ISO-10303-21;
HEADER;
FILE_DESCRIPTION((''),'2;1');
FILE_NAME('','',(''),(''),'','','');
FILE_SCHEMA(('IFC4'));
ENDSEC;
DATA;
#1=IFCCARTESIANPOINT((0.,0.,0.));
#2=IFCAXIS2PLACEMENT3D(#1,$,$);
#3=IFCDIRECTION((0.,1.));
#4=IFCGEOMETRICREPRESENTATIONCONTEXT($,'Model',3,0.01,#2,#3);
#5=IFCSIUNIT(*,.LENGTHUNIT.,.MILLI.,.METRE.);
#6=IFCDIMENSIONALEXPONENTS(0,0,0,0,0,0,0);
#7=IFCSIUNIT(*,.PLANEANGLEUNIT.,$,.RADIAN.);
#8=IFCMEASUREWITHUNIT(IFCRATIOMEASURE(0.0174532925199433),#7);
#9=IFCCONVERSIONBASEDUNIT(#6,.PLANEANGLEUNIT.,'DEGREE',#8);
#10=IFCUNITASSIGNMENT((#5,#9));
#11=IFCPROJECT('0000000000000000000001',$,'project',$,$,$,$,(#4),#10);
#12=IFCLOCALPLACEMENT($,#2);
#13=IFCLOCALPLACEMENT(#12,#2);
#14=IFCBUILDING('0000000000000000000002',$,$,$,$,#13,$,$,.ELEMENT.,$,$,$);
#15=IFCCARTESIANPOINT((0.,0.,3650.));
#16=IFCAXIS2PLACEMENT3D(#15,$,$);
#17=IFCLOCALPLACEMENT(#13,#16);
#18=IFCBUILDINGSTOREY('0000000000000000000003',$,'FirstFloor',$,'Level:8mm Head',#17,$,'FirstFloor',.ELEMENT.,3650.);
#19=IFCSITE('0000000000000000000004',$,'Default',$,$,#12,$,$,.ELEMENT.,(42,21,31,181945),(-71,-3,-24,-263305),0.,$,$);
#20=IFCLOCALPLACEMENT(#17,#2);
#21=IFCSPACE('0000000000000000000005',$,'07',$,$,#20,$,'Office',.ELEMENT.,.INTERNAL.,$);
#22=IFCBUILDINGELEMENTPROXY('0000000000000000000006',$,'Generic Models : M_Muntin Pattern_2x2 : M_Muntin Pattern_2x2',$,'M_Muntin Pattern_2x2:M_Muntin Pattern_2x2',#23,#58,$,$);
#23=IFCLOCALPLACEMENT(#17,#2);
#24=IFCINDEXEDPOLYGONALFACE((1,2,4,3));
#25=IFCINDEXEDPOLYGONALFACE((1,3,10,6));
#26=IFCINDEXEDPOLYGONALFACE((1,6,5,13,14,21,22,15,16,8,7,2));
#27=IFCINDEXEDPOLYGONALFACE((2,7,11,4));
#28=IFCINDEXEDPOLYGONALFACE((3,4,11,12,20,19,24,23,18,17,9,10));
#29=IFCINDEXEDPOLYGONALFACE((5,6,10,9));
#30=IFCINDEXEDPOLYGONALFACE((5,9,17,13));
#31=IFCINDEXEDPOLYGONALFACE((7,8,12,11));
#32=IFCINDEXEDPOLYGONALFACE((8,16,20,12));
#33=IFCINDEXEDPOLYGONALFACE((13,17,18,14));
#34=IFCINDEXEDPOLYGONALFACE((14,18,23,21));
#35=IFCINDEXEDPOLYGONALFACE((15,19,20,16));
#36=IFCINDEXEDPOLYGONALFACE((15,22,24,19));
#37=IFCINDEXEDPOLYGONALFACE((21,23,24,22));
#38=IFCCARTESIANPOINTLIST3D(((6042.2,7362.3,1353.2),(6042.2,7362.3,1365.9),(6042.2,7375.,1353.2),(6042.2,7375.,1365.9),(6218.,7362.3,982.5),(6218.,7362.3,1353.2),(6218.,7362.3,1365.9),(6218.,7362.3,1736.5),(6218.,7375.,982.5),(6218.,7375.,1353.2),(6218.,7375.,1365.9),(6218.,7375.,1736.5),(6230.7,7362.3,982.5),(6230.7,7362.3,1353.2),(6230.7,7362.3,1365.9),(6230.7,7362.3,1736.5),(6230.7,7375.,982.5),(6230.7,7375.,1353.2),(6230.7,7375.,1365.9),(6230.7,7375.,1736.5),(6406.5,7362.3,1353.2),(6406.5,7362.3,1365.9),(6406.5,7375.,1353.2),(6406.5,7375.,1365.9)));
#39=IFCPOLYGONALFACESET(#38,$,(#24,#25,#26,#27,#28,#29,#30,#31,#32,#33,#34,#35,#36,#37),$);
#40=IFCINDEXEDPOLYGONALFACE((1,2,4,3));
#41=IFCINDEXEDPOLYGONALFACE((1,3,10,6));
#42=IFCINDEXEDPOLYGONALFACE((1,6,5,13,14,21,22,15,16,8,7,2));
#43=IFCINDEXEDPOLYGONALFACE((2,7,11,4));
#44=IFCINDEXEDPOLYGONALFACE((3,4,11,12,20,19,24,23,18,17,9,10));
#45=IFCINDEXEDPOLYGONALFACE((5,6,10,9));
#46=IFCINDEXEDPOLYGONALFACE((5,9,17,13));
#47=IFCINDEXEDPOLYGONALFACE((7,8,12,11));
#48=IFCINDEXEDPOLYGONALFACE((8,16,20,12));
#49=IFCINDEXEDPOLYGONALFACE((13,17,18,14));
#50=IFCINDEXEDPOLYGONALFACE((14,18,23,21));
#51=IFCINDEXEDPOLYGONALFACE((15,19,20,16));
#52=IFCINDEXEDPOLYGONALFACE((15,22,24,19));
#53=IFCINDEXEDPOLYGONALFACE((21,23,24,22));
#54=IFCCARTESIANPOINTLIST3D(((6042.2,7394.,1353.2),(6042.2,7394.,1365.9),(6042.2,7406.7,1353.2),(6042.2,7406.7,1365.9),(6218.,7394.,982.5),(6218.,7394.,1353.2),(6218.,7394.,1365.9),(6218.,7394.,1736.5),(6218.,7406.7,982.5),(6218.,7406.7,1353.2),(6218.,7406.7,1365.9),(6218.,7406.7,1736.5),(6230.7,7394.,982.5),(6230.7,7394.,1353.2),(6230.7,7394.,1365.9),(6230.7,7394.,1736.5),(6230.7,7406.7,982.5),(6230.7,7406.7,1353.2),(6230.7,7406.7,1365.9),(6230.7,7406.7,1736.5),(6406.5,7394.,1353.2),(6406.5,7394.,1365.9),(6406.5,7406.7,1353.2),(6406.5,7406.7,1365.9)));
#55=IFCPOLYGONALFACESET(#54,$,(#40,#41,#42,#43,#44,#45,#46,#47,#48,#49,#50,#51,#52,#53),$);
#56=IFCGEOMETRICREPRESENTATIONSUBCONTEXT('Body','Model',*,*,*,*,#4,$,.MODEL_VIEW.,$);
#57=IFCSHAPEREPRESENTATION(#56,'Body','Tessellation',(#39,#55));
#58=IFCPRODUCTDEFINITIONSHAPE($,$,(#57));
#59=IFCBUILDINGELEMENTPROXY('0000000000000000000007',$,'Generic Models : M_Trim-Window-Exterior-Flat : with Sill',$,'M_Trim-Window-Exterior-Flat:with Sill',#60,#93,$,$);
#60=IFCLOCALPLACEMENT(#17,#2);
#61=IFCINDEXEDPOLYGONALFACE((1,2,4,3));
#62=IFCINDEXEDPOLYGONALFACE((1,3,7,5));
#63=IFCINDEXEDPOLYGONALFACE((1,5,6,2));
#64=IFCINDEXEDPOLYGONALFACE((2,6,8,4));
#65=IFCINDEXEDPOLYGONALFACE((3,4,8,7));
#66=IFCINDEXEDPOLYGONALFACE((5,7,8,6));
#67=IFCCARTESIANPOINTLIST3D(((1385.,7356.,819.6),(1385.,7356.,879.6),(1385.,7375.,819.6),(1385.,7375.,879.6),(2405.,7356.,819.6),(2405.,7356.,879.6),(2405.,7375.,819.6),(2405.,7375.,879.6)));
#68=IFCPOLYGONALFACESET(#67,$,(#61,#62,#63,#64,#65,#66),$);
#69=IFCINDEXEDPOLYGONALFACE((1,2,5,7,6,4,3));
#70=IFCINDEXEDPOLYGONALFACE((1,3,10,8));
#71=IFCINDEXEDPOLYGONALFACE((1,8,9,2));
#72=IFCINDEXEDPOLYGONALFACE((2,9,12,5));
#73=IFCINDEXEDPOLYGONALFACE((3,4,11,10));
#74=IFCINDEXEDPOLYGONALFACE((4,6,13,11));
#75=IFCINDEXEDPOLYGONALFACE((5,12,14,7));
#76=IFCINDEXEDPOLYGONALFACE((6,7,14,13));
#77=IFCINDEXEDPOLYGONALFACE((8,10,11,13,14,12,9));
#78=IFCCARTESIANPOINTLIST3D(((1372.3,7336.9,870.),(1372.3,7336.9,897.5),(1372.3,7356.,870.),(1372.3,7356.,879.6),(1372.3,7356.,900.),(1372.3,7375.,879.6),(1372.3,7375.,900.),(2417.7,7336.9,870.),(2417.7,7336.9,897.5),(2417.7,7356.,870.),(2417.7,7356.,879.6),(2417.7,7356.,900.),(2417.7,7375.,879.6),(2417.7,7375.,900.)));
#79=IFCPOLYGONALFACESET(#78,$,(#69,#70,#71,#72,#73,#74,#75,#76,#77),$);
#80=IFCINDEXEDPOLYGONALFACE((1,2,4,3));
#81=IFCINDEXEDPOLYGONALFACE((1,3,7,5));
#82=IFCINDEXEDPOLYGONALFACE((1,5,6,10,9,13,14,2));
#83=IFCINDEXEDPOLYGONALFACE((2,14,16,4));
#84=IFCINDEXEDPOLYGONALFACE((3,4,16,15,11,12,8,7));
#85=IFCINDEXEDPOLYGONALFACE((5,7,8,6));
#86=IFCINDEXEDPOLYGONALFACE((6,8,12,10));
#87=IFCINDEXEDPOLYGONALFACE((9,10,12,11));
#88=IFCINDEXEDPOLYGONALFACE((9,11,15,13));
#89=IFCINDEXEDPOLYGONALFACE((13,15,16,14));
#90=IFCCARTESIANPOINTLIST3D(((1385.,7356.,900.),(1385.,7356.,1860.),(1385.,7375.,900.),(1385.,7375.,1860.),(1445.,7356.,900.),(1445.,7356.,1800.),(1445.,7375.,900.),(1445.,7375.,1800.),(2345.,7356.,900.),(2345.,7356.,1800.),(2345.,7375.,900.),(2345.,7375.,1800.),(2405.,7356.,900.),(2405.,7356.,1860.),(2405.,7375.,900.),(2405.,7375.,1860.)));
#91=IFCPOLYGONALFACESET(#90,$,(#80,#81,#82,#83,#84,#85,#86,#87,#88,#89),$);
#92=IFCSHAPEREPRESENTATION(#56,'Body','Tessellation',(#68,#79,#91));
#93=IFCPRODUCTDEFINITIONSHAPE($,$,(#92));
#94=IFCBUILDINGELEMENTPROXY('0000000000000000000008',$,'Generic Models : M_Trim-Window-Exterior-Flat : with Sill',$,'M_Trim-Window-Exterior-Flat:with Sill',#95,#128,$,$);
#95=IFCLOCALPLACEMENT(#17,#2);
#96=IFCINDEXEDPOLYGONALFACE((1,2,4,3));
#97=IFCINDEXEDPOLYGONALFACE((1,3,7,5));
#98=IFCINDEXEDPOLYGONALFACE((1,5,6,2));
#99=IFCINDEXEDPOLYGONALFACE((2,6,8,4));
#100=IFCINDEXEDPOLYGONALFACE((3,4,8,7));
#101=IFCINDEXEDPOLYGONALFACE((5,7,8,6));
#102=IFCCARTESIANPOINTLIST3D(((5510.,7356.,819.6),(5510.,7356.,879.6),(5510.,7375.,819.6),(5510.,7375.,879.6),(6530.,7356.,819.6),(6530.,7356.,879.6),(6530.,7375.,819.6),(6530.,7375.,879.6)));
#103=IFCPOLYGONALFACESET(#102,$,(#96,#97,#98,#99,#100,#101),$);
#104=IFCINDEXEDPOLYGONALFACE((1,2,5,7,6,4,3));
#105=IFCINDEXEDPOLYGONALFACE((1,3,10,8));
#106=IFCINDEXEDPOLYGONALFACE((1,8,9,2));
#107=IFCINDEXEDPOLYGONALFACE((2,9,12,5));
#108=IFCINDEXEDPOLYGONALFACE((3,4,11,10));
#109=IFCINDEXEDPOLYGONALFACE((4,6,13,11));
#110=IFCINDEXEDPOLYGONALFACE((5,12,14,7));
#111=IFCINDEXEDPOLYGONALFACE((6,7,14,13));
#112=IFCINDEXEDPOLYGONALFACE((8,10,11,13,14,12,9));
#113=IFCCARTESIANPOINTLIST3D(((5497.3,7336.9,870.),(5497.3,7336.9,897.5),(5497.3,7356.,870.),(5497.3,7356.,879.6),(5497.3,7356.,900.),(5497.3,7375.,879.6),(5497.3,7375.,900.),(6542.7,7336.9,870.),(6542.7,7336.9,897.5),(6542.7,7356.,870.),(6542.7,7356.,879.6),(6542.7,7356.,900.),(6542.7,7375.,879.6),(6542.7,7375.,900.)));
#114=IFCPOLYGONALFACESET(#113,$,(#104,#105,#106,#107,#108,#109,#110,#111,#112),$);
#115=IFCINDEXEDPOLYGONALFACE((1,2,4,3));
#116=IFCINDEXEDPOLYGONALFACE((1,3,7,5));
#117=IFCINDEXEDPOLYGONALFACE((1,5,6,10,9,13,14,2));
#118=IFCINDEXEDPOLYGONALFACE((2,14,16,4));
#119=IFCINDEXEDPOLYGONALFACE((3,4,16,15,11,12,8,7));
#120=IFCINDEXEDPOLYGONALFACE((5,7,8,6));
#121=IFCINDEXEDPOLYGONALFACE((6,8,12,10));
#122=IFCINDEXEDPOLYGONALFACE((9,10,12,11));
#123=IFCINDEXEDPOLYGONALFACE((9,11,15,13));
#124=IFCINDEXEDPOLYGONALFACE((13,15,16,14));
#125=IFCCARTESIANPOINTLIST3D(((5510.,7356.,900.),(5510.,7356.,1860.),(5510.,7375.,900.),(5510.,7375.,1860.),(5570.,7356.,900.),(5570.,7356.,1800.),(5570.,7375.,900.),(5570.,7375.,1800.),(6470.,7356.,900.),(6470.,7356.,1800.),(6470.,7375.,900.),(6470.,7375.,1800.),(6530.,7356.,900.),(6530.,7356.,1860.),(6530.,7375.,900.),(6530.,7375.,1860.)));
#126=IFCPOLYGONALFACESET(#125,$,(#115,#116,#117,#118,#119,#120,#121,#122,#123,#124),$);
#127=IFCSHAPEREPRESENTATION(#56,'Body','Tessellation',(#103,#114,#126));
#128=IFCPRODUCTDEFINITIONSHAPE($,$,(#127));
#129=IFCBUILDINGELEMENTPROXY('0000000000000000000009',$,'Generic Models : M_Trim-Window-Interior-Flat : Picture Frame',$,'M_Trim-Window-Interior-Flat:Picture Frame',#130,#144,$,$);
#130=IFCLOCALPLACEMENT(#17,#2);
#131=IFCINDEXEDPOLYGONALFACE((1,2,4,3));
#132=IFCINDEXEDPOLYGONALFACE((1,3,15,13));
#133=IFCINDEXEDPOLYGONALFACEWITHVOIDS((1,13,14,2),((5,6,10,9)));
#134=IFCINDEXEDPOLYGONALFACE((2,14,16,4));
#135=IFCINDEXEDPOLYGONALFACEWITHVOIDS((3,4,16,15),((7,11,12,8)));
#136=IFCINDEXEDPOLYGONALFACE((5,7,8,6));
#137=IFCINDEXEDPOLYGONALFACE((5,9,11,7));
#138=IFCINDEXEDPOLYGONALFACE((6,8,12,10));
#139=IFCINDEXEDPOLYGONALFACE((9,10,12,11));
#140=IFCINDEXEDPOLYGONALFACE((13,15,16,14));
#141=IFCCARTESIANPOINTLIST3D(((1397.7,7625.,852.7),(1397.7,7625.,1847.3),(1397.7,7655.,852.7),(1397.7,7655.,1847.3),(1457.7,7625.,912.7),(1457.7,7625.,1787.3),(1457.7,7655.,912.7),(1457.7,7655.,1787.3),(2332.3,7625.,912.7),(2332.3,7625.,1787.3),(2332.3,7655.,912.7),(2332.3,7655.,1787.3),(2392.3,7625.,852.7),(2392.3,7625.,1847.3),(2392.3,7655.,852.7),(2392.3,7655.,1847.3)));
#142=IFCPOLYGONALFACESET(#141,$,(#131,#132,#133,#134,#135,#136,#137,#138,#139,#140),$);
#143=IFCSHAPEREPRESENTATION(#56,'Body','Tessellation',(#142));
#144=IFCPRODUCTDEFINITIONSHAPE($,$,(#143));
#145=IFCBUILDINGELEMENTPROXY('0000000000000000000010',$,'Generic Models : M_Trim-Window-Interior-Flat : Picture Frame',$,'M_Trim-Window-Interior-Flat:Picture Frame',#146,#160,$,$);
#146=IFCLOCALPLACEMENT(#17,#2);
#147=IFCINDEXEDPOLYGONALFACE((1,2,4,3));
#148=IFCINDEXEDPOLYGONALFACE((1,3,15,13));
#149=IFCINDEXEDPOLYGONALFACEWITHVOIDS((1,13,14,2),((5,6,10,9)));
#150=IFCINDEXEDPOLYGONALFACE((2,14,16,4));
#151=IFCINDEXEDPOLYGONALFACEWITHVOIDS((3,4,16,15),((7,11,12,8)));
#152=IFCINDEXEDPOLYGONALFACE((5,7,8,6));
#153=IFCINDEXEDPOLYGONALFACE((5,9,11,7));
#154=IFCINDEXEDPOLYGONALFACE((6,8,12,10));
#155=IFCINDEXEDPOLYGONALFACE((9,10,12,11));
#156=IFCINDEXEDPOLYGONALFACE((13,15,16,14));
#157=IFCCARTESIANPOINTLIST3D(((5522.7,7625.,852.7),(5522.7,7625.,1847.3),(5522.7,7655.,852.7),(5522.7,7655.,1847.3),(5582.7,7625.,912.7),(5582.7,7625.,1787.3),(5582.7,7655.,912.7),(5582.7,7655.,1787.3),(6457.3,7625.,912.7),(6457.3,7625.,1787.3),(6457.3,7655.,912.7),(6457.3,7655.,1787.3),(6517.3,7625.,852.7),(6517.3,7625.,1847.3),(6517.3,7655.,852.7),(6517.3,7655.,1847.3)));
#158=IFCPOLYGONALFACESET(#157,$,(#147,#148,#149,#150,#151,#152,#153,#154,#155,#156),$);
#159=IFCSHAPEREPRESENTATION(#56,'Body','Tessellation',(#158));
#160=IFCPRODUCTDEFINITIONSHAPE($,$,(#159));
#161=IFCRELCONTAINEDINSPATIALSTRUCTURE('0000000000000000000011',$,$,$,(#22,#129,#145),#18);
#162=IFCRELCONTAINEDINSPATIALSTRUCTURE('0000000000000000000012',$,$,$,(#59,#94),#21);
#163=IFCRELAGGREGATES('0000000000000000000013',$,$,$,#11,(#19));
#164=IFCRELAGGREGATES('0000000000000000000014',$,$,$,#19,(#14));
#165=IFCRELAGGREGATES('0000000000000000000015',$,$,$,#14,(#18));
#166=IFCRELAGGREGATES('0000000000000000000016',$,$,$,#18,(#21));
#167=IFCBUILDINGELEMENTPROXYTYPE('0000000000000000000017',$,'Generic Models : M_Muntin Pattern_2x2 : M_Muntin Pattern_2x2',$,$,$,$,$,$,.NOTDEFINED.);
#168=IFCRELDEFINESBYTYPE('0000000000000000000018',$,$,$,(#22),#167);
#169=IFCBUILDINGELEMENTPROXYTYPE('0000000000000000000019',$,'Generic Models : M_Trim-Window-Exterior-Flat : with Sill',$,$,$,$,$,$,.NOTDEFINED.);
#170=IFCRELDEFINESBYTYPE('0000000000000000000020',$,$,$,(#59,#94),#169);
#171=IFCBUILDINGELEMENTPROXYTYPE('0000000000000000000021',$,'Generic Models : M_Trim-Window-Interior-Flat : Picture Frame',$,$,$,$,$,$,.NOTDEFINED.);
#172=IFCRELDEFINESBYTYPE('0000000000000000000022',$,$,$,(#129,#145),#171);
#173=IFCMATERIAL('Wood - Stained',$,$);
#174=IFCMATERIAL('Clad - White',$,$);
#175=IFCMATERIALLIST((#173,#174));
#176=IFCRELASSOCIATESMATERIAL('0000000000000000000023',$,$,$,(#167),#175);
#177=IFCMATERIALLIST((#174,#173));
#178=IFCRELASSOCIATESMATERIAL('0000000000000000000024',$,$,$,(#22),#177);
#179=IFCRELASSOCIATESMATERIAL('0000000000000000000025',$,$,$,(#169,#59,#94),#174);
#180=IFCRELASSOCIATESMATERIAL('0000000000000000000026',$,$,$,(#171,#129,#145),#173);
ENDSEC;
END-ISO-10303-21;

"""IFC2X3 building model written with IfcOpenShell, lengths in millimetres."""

from ifc_helpers import new_model, entity, si_unit, converted_unit, direction, frame, frame_2d, origin, place, context, subcontext, project, spatial, polyline, rectangle, outline, extrude, source, transform, mapped, material, material_list, type_object, type_shapes, element, save


model = new_model("IFC2X3")

# Units and contexts
model_context = context("Model", 3, precision=0.01, world=origin(), true_north=direction((0.0, 1.0)))
body_context = subcontext(model_context, "Body", "Model", "MODEL_VIEW")
ifc_project = project(units=[si_unit("LENGTHUNIT", "METRE", prefix="MILLI"), converted_unit("PLANEANGLEUNIT", "DEGREE", entity("IfcRatioMeasure", 0.0174532925199433), si_unit("PLANEANGLEUNIT", "RADIAN"), dimensions=[0, 0, 0, 0, 0, 0, 0])], contexts=[model_context])

# Site, building, storey
site_placement = place(None, origin())
site = spatial("IfcSite", under=ifc_project, at=site_placement, Name="Default", CompositionType="ELEMENT", RefLatitude=(42, 21, 31, 181945), RefLongitude=(-71, -3, -24, -263305), RefElevation=0.0)
building_placement = place(site_placement, origin())
building = spatial("IfcBuilding", under=site, at=building_placement, CompositionType="ELEMENT")
storey_placement = place(building_placement, frame((0.0, 0.0, 3650.0)))
storey = spatial("IfcBuildingStorey", under=building, at=storey_placement, Name="FirstFloor", ObjectType="Level:8mm Head", LongName="FirstFloor", CompositionType="ELEMENT", Elevation=3650.0)

# Shared definitions
ifc_material_1 = material(Name="Clad - White")
ifc_material_2 = material(Name="Wood - Stained")

# Shared definitions
space_placement = place(storey_placement, origin())
space = spatial("IfcSpace", under=storey, at=space_placement, Name="07", LongName="Office", CompositionType="ELEMENT", InteriorOrExteriorSpace="INTERNAL")

# Building element proxies
ifc_material_list_1 = material_list([ifc_material_2, ifc_material_1])
building_element_proxy_type_1 = type_object("IfcBuildingElementProxyType", Name="Generic Models : M_Muntin Pattern_2x2 : M_Muntin Pattern_2x2", PredefinedType="NOTDEFINED", material=ifc_material_list_1)
shared_shape_1 = source(origin(), body_context, "Body", "SweptSolid", [
    extrude(outline(polyline([(6.4, -6.4), (377.0, -6.4), (377.0, 6.3), (6.4, 6.3), (6.4, 182.1), (-6.3, 182.1), (-6.3, 6.3), (-377.0, 6.3), (-377.0, -6.4), (-6.3, -6.4), (-6.3, -182.1), (6.4, -182.1), (6.4, -6.4)])), frame((0.0, 9.5, 377.0), z_axis=(0.0, 1.0, 0.0), x_axis=(0.0, 0.0, 1.0)), (0.0, 0.0, 1.0), 12.7),
    extrude(outline(polyline([(6.4, -6.4), (377.0, -6.4), (377.0, 6.3), (6.4, 6.3), (6.4, 182.1), (-6.3, 182.1), (-6.3, 6.3), (-377.0, 6.3), (-377.0, -6.4), (-6.3, -6.4), (-6.3, -182.1), (6.4, -182.1), (6.4, -6.4)])), frame((0.0, -22.2, 377.0), z_axis=(0.0, 1.0, 0.0), x_axis=(0.0, 0.0, 1.0)), (0.0, 0.0, 1.0), 12.7),
])
type_shapes(building_element_proxy_type_1, [shared_shape_1])
ifc_material_list_2 = material_list([ifc_material_1, ifc_material_2])
proxy_1_placement = place(storey_placement, frame((6224.4, 7384.5, 982.5), z_axis=(0.0, 0.0, 1.0), x_axis=(-1.0, 0.0, 0.0)))
element("IfcBuildingElementProxy", 1, at=proxy_1_placement, inside=storey, type_object=building_element_proxy_type_1, material=ifc_material_list_2, Name="Generic Models : M_Muntin Pattern_2x2 : M_Muntin Pattern_2x2", ObjectType="M_Muntin Pattern_2x2:M_Muntin Pattern_2x2", context=body_context, shape_type="MappedRepresentation", body=[
    mapped(shared_shape_1, transform((0.0, 0.0, 0.0), scale=1.0)),
])
building_element_proxy_type_2 = type_object("IfcBuildingElementProxyType", Name="Generic Models : M_Trim-Window-Exterior-Flat : with Sill", PredefinedType="NOTDEFINED", material=ifc_material_1)
shared_shape_2 = source(origin(), body_context, "Body", "SweptSolid", [
    extrude(rectangle(XDim=1020.0, YDim=60.0, at=frame_2d((0.0, 0.0), x_axis=(1.0, 0.0))), frame((0.0, -950.4, 0.0), z_axis=(0.0, 0.0, 1.0), x_axis=(-1.0, 0.0, 0.0)), (0.0, 0.0, 1.0), 19.1),
    extrude(outline(polyline([(-19.0, -15.2), (0.0, -15.2), (0.0, -5.7), (19.0, -5.7), (19.0, 14.8), (0.0, 14.8), (-19.0, 12.3), (-19.0, -15.2)])), frame((-522.7, -914.8, 19.0), z_axis=(1.0, 0.0, 0.0), x_axis=(0.0, 0.0, -1.0)), (0.0, 0.0, 1.0), 1045.4),
    extrude(outline(polyline([(-495.0, -510.0), (465.0, -510.0), (465.0, -450.0), (-435.0, -450.0), (-435.0, 450.0), (465.0, 450.0), (465.0, 510.0), (-495.0, 510.0), (-495.0, -510.0)])), frame((0.0, -435.0, 0.0), z_axis=(0.0, 0.0, 1.0), x_axis=(0.0, -1.0, 0.0)), (0.0, 0.0, 1.0), 19.1),
])
type_shapes(building_element_proxy_type_2, [shared_shape_2])
for number, where, z_axis, x_axis, name in (
    (2, (1895.0, 7375.0, 1800.0), (0.0, -1.0, 0.0), (1.0, 0.0, 0.0), "Generic Models : M_Trim-Window-Exterior-Flat : with Sill"),
    (3, (6020.0, 7375.0, 1800.0), (0.0, -1.0, 0.0), (1.0, 0.0, 0.0), "Generic Models : M_Trim-Window-Exterior-Flat : with Sill"),
):
    element("IfcBuildingElementProxy", number, at=place(space_placement, frame(where, z_axis=z_axis, x_axis=x_axis)), inside=space, type_object=building_element_proxy_type_2, material=ifc_material_1, Name=name, ObjectType="M_Trim-Window-Exterior-Flat:with Sill", context=body_context, shape_type="MappedRepresentation", body=[
        mapped(shared_shape_2, transform((0.0, 0.0, 0.0), scale=1.0)),
    ])
building_element_proxy_type_3 = type_object("IfcBuildingElementProxyType", Name="Generic Models : M_Trim-Window-Interior-Flat : Picture Frame", PredefinedType="NOTDEFINED", material=ifc_material_2)
shared_shape_3 = source(origin(), body_context, "Body", "SweptSolid", [
    extrude(outline(polyline([(-497.3, -497.3), (497.3, -497.3), (497.3, 497.3), (-497.3, 497.3), (-497.3, -497.3)]), holes=[polyline([(-437.3, -437.3), (-437.3, 437.3), (437.3, 437.3), (437.3, -437.3), (-437.3, -437.3)])]), frame((0.0, -450.0, 0.0), z_axis=(0.0, 0.0, 1.0), x_axis=(-1.0, 0.0, 0.0)), (0.0, 0.0, 1.0), 30.0),
])
type_shapes(building_element_proxy_type_3, [shared_shape_3])
for number, where, z_axis, x_axis, name in (
    (4, (1895.0, 7625.0, 1800.0), (0.0, 1.0, 0.0), (-1.0, 0.0, 0.0), "Generic Models : M_Trim-Window-Interior-Flat : Picture Frame"),
    (5, (6020.0, 7625.0, 1800.0), (0.0, 1.0, 0.0), (-1.0, 0.0, 0.0), "Generic Models : M_Trim-Window-Interior-Flat : Picture Frame"),
):
    element("IfcBuildingElementProxy", number, at=place(storey_placement, frame(where, z_axis=z_axis, x_axis=x_axis)), inside=storey, type_object=building_element_proxy_type_3, material=ifc_material_2, Name=name, ObjectType="M_Trim-Window-Interior-Flat:Picture Frame", context=body_context, shape_type="MappedRepresentation", body=[
        mapped(shared_shape_3, transform((0.0, 0.0, 0.0), scale=1.0)),
    ])

save(model, "model.ifc")
